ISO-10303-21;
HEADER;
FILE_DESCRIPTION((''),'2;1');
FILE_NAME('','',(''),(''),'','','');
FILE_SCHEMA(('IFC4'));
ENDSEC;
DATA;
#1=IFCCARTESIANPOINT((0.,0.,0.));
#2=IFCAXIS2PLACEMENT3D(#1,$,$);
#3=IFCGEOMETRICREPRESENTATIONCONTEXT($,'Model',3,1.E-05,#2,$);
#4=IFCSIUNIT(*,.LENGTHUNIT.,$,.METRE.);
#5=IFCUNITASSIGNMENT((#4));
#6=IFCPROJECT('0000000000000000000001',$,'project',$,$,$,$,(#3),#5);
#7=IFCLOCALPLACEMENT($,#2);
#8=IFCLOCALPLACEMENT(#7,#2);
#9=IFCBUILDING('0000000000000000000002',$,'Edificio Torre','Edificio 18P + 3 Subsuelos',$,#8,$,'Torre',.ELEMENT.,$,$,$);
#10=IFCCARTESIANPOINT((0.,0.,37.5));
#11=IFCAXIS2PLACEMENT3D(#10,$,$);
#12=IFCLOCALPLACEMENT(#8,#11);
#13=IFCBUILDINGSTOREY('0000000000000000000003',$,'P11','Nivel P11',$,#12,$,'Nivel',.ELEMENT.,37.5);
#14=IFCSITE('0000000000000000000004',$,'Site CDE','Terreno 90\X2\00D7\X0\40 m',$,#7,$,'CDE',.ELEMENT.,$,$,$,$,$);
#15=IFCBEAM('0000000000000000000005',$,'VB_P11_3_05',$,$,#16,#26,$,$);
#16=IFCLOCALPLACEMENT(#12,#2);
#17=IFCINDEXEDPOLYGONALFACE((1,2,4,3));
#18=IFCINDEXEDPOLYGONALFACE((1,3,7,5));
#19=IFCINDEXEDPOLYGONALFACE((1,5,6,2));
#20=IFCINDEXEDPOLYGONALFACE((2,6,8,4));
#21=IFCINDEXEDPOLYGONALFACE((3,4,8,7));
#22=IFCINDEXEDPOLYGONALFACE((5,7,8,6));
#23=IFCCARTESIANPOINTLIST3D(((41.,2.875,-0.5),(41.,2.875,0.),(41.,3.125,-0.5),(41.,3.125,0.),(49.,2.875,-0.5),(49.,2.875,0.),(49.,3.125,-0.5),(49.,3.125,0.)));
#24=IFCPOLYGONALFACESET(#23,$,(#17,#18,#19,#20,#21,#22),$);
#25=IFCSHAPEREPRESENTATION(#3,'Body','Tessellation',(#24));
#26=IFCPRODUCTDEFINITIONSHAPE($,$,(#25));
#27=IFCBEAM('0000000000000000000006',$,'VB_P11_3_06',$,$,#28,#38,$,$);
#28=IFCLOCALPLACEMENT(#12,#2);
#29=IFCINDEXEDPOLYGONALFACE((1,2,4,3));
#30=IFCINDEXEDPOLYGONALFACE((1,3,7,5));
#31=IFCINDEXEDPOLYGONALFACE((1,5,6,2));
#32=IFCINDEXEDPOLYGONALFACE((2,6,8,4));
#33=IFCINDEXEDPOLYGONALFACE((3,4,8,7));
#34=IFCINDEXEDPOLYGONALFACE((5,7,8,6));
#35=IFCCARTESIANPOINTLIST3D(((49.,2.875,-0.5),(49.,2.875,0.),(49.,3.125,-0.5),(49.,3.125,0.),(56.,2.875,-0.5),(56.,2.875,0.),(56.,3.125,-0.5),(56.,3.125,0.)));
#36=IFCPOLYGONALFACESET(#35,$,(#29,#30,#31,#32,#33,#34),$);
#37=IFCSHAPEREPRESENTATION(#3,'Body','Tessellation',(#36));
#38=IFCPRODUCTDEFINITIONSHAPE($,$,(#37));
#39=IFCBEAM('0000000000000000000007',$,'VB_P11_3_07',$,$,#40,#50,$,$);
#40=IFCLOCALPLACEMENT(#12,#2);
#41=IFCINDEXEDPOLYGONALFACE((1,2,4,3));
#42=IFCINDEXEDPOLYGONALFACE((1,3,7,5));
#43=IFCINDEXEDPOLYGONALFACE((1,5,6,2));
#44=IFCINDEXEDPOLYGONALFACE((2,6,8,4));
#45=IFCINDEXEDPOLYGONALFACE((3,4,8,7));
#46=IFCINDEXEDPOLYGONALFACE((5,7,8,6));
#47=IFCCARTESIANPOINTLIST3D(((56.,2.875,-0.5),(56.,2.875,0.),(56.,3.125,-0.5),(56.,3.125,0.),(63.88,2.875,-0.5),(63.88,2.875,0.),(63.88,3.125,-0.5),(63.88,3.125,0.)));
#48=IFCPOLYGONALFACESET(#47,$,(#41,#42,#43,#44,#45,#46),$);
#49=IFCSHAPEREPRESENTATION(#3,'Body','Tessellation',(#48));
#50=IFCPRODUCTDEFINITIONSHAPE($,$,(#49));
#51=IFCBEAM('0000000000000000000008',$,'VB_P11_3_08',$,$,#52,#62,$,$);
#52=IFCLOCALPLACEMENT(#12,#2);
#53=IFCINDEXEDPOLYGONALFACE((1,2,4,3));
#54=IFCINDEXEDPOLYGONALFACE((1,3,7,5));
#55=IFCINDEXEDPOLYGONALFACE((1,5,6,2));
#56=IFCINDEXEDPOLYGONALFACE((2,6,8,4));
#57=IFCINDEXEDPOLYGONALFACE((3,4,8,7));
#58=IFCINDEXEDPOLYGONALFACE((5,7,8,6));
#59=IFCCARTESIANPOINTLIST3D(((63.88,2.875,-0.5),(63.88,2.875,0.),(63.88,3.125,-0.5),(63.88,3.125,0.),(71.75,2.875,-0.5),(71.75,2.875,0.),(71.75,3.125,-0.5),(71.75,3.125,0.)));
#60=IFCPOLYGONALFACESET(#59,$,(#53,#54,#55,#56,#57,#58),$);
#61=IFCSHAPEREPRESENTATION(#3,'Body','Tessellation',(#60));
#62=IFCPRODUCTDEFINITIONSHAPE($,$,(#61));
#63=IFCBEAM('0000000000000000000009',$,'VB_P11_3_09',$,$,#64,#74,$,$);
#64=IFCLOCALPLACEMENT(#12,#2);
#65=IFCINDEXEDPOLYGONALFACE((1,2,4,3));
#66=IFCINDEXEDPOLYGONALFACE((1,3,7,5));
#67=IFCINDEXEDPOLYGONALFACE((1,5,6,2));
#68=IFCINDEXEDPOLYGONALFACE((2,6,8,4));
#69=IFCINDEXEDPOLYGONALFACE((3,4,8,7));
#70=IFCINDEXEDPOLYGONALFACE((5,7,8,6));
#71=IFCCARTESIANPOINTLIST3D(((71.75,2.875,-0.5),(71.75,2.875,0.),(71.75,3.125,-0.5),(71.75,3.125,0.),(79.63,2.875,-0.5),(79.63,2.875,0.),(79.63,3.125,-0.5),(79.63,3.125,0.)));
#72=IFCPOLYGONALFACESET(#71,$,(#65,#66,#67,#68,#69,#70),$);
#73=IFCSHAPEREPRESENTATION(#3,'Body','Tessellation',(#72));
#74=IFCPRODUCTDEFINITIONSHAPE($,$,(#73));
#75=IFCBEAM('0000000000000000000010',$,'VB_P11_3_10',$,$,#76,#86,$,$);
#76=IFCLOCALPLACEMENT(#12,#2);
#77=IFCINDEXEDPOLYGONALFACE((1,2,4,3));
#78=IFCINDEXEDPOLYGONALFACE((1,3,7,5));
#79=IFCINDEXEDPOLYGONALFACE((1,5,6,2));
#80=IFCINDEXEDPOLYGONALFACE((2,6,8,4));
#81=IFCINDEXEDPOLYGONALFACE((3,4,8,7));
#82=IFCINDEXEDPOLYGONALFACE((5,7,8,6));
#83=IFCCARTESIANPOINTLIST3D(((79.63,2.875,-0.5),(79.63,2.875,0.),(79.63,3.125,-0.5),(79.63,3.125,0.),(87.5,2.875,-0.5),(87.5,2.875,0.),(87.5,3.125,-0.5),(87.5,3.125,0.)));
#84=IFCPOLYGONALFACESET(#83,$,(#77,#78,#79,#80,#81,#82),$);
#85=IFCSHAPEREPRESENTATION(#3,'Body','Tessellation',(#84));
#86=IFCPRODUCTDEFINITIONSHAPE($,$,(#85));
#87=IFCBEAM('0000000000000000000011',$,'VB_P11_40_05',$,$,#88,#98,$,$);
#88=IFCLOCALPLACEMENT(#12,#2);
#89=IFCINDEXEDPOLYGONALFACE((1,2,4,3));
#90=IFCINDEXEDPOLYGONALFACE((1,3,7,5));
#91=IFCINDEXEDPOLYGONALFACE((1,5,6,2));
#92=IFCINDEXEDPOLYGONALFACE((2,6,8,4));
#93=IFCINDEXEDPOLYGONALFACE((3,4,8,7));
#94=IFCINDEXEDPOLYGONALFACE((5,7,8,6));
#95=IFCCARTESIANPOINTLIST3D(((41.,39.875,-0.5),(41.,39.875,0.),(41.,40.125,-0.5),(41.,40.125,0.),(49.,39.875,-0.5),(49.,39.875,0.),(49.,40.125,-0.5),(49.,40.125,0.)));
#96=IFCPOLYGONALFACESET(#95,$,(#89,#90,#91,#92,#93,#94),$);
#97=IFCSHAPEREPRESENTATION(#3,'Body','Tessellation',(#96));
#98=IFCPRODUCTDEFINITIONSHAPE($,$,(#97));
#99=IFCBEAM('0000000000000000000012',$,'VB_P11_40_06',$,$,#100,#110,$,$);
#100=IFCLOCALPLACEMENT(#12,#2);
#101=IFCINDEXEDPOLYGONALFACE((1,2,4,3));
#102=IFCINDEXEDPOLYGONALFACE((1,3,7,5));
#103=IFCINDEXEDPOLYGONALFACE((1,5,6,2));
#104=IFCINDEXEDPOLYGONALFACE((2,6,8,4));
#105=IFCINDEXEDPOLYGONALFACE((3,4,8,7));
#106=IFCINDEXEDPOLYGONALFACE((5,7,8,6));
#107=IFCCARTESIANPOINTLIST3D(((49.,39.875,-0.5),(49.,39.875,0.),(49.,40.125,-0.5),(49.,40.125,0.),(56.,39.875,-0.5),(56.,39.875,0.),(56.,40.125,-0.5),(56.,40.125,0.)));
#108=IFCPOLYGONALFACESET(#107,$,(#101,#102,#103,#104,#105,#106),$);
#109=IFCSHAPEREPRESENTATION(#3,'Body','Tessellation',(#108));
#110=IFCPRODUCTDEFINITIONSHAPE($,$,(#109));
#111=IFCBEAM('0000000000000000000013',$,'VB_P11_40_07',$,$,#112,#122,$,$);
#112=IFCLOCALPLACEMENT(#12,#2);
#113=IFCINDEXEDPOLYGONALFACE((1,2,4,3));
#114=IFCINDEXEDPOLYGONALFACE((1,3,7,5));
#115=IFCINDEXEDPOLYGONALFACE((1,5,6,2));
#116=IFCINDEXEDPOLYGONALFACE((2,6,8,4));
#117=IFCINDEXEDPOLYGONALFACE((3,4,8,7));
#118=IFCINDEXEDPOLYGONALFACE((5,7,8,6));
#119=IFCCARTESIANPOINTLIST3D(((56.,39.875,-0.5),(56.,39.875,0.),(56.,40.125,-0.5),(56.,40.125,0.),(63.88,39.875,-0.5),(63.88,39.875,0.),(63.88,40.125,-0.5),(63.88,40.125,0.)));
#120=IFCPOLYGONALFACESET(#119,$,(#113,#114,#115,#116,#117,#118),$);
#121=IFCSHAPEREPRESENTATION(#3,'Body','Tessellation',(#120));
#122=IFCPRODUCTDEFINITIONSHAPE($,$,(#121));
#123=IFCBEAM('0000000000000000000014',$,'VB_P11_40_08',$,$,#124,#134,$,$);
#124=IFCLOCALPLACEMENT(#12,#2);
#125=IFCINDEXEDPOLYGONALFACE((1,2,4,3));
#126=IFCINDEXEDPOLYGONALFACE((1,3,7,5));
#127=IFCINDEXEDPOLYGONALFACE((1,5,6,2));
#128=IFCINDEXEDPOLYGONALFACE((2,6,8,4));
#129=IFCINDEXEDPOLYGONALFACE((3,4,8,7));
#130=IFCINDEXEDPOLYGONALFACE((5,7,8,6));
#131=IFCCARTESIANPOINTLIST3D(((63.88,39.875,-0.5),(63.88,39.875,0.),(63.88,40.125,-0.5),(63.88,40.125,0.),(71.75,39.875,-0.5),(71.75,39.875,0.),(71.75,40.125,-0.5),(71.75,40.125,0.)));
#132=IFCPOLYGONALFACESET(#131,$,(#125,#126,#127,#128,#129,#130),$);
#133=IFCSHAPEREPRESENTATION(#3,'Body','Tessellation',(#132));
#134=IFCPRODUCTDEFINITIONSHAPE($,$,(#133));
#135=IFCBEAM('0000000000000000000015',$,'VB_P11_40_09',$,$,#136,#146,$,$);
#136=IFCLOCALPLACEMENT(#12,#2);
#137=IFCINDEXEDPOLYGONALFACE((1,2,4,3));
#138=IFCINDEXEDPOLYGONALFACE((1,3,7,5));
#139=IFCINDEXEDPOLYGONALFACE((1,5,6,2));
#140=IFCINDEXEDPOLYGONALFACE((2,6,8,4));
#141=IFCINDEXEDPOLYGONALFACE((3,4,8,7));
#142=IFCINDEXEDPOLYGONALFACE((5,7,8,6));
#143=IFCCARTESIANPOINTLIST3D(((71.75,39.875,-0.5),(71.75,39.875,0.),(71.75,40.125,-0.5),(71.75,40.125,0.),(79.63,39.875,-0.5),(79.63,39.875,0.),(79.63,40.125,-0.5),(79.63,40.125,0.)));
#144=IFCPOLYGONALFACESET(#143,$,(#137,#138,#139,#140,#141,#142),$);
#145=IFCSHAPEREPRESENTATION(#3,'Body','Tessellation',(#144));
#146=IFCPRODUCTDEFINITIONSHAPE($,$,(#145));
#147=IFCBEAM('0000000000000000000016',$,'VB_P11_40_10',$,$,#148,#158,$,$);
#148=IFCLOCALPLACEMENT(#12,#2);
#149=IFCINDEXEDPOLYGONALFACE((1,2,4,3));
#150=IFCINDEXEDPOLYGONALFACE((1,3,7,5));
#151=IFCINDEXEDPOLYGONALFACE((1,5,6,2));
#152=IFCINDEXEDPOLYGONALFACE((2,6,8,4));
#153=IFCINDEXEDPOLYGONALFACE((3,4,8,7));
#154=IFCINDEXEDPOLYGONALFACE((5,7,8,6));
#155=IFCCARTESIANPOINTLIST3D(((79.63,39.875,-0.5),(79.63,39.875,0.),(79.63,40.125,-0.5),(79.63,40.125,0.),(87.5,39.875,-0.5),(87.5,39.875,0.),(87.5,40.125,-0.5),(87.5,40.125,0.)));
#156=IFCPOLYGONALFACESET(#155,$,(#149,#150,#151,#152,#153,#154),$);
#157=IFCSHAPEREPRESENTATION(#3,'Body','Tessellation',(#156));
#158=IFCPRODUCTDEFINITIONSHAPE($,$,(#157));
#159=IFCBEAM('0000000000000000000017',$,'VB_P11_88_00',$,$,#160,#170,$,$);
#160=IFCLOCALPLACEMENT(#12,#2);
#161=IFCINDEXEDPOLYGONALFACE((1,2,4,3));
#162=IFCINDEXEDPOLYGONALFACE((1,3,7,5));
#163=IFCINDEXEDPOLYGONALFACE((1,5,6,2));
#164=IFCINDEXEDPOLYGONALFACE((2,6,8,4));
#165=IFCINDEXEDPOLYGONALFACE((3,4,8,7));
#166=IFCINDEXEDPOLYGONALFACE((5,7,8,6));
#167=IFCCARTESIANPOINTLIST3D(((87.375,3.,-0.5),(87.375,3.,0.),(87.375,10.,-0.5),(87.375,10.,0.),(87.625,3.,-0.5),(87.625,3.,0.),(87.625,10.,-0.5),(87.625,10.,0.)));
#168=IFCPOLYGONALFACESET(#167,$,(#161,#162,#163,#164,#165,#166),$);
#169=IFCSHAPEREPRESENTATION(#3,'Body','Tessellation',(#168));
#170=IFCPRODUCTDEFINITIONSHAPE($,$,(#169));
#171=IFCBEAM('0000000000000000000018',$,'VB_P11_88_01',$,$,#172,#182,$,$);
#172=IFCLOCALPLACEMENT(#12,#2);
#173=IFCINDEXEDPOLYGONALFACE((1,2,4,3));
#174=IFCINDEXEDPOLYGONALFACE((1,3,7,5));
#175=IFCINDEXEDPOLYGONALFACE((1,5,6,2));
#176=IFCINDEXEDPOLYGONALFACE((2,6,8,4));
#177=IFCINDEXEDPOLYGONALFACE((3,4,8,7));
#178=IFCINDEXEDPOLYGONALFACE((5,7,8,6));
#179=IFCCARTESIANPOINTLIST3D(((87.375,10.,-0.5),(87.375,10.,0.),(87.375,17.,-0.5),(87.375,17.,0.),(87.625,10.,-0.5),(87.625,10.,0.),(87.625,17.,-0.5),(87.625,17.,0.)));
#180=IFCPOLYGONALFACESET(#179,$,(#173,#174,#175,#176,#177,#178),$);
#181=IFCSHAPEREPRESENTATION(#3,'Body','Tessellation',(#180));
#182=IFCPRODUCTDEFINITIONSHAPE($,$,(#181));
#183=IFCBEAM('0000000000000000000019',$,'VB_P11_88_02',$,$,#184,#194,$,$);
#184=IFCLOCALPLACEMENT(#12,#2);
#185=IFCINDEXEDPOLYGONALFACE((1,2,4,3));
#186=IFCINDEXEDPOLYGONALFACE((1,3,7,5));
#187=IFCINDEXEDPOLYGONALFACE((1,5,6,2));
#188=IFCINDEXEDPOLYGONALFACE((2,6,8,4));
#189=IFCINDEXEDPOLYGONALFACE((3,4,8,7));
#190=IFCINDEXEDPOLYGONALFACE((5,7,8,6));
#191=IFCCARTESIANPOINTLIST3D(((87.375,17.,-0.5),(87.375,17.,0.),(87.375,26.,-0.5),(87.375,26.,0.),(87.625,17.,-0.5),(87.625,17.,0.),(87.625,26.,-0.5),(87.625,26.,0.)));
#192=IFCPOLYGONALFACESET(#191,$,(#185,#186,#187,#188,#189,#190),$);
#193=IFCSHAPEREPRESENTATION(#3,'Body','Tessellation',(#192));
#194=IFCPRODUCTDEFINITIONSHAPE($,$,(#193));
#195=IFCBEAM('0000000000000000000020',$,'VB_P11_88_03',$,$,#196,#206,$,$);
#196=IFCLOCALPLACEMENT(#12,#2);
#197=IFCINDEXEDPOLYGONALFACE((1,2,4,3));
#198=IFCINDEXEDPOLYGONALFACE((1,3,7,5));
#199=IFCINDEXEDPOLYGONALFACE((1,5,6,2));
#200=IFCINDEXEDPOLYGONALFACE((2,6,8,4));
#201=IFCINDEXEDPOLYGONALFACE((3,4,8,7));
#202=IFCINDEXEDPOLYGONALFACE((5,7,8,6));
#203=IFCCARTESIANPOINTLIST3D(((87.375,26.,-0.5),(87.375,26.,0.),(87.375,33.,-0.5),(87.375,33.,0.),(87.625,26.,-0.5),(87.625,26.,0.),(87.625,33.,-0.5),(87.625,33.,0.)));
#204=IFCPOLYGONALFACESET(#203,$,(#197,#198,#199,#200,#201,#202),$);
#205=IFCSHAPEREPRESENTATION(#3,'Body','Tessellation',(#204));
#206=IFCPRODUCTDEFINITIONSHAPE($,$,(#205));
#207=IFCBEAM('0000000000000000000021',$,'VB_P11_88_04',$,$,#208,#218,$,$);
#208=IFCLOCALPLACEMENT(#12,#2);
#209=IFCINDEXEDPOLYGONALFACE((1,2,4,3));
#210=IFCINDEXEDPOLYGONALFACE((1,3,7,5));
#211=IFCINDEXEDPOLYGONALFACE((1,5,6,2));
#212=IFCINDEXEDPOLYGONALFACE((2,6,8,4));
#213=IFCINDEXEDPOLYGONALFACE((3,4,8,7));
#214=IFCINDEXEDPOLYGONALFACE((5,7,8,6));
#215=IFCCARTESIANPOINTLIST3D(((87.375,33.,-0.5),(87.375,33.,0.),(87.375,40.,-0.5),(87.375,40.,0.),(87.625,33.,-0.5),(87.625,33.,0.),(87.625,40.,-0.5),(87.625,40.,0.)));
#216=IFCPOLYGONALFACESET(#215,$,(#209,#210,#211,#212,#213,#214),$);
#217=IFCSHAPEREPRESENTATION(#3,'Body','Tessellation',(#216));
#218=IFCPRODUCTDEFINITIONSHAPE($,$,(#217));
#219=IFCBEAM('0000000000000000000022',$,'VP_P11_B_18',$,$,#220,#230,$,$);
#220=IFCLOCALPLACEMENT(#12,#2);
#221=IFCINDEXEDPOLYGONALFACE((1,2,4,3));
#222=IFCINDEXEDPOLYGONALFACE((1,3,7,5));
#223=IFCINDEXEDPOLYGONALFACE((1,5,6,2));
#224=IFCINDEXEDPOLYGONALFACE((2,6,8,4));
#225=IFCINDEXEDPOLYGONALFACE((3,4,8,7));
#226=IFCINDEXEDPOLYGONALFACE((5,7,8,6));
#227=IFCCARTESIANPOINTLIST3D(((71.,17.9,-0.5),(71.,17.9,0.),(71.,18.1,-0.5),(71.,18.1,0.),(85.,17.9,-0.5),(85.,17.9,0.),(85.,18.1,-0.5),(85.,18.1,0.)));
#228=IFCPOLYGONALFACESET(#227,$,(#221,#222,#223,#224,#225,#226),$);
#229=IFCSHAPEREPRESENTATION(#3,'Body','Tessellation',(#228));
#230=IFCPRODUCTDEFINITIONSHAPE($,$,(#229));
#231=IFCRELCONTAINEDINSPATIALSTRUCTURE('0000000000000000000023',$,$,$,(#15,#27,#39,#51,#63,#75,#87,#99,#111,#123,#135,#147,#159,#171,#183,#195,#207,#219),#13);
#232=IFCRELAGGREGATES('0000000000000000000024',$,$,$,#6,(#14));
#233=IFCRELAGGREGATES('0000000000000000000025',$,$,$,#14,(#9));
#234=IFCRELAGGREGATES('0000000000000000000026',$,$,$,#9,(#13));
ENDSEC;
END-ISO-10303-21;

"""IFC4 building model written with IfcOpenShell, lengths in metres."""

from ifc_helpers import new_model, si_unit, frame, origin, origin_2d, place, context, project, spatial, rectangle, extrude, element, save


model = new_model("IFC4")

# Units and contexts
model_context = context("Model", 3, precision=1e-05, world=origin())
ifc_project = project(units=[si_unit("LENGTHUNIT", "METRE")], contexts=[model_context])

# Site, building, storey
site_placement = place(None, origin())
site = spatial("IfcSite", under=ifc_project, at=site_placement, Name="Site CDE", Description="Terreno 90×40 m", LongName="CDE", CompositionType="ELEMENT")
building_placement = place(site_placement, origin())
building = spatial("IfcBuilding", under=site, at=building_placement, Name="Edificio Torre", Description="Edificio 18P + 3 Subsuelos", LongName="Torre", CompositionType="ELEMENT")
storey_placement = place(building_placement, frame((0.0, 0.0, 37.5)))
storey = spatial("IfcBuildingStorey", under=building, at=storey_placement, Name="P11", Description="Nivel P11", LongName="Nivel", CompositionType="ELEMENT", Elevation=37.5)

# Beams
beam_1_placement = place(storey_placement, frame((45.0, 3.0, -0.5)))
element("IfcBeam", 1, at=beam_1_placement, inside=storey, Name="VB_P11_3_05", context=model_context, shape_type="SweptSolid", body=[
    extrude(rectangle(XDim=8.0, YDim=0.25, at=origin_2d()), origin(), (0.0, 0.0, 1.0), 0.5),
])
beam_2_placement = place(storey_placement, frame((52.5, 3.0, -0.5)))
element("IfcBeam", 2, at=beam_2_placement, inside=storey, Name="VB_P11_3_06", context=model_context, shape_type="SweptSolid", body=[
    extrude(rectangle(XDim=7.0, YDim=0.25, at=origin_2d()), origin(), (0.0, 0.0, 1.0), 0.5),
])
beam_3_placement = place(storey_placement, frame((59.94, 3.0, -0.5)))
element("IfcBeam", 3, at=beam_3_placement, inside=storey, Name="VB_P11_3_07", context=model_context, shape_type="SweptSolid", body=[
    extrude(rectangle(XDim=7.88, YDim=0.25, at=origin_2d()), origin(), (0.0, 0.0, 1.0), 0.5),
])
beam_4_placement = place(storey_placement, frame((67.815, 3.0, -0.5)))
element("IfcBeam", 4, at=beam_4_placement, inside=storey, Name="VB_P11_3_08", context=model_context, shape_type="SweptSolid", body=[
    extrude(rectangle(XDim=7.87, YDim=0.25, at=origin_2d()), origin(), (0.0, 0.0, 1.0), 0.5),
])
beam_5_placement = place(storey_placement, frame((75.69, 3.0, -0.5)))
element("IfcBeam", 5, at=beam_5_placement, inside=storey, Name="VB_P11_3_09", context=model_context, shape_type="SweptSolid", body=[
    extrude(rectangle(XDim=7.88, YDim=0.25, at=origin_2d()), origin(), (0.0, 0.0, 1.0), 0.5),
])
beam_6_placement = place(storey_placement, frame((83.565, 3.0, -0.5)))
element("IfcBeam", 6, at=beam_6_placement, inside=storey, Name="VB_P11_3_10", context=model_context, shape_type="SweptSolid", body=[
    extrude(rectangle(XDim=7.87, YDim=0.25, at=origin_2d()), origin(), (0.0, 0.0, 1.0), 0.5),
])
beam_7_placement = place(storey_placement, frame((45.0, 40.0, -0.5)))
element("IfcBeam", 7, at=beam_7_placement, inside=storey, Name="VB_P11_40_05", context=model_context, shape_type="SweptSolid", body=[
    extrude(rectangle(XDim=8.0, YDim=0.25, at=origin_2d()), origin(), (0.0, 0.0, 1.0), 0.5),
])
beam_8_placement = place(storey_placement, frame((52.5, 40.0, -0.5)))
element("IfcBeam", 8, at=beam_8_placement, inside=storey, Name="VB_P11_40_06", context=model_context, shape_type="SweptSolid", body=[
    extrude(rectangle(XDim=7.0, YDim=0.25, at=origin_2d()), origin(), (0.0, 0.0, 1.0), 0.5),
])
beam_9_placement = place(storey_placement, frame((59.94, 40.0, -0.5)))
element("IfcBeam", 9, at=beam_9_placement, inside=storey, Name="VB_P11_40_07", context=model_context, shape_type="SweptSolid", body=[
    extrude(rectangle(XDim=7.88, YDim=0.25, at=origin_2d()), origin(), (0.0, 0.0, 1.0), 0.5),
])
beam_10_placement = place(storey_placement, frame((67.815, 40.0, -0.5)))
element("IfcBeam", 10, at=beam_10_placement, inside=storey, Name="VB_P11_40_08", context=model_context, shape_type="SweptSolid", body=[
    extrude(rectangle(XDim=7.87, YDim=0.25, at=origin_2d()), origin(), (0.0, 0.0, 1.0), 0.5),
])
beam_11_placement = place(storey_placement, frame((75.69, 40.0, -0.5)))
element("IfcBeam", 11, at=beam_11_placement, inside=storey, Name="VB_P11_40_09", context=model_context, shape_type="SweptSolid", body=[
    extrude(rectangle(XDim=7.88, YDim=0.25, at=origin_2d()), origin(), (0.0, 0.0, 1.0), 0.5),
])
beam_12_placement = place(storey_placement, frame((83.565, 40.0, -0.5)))
element("IfcBeam", 12, at=beam_12_placement, inside=storey, Name="VB_P11_40_10", context=model_context, shape_type="SweptSolid", body=[
    extrude(rectangle(XDim=7.87, YDim=0.25, at=origin_2d()), origin(), (0.0, 0.0, 1.0), 0.5),
])
for number, where, name in (
    (13, (87.5, 6.5, -0.5), "VB_P11_88_00"),
    (14, (87.5, 13.5, -0.5), "VB_P11_88_01"),
):
    element("IfcBeam", number, at=place(storey_placement, frame(where)), inside=storey, Name=name, context=model_context, shape_type="SweptSolid", body=[
        extrude(rectangle(XDim=0.25, YDim=7.0, at=origin_2d()), origin(), (0.0, 0.0, 1.0), 0.5),
    ])
beam_13_placement = place(storey_placement, frame((87.5, 21.5, -0.5)))
element("IfcBeam", 15, at=beam_13_placement, inside=storey, Name="VB_P11_88_02", context=model_context, shape_type="SweptSolid", body=[
    extrude(rectangle(XDim=0.25, YDim=9.0, at=origin_2d()), origin(), (0.0, 0.0, 1.0), 0.5),
])
for number, where, name in (
    (16, (87.5, 29.5, -0.5), "VB_P11_88_03"),
    (17, (87.5, 36.5, -0.5), "VB_P11_88_04"),
):
    element("IfcBeam", number, at=place(storey_placement, frame(where)), inside=storey, Name=name, context=model_context, shape_type="SweptSolid", body=[
        extrude(rectangle(XDim=0.25, YDim=7.0, at=origin_2d()), origin(), (0.0, 0.0, 1.0), 0.5),
    ])
for number, where, name in (
    (18, (78.0, 18.0, -0.5), "VP_P11_B_18"),
):
    element("IfcBeam", number, at=place(storey_placement, frame(where)), inside=storey, Name=name, context=model_context, shape_type="SweptSolid", body=[
        extrude(rectangle(XDim=14.0, YDim=0.2, at=origin_2d()), origin(), (0.0, 0.0, 1.0), 0.5),
    ])

save(model, "model.ifc")
